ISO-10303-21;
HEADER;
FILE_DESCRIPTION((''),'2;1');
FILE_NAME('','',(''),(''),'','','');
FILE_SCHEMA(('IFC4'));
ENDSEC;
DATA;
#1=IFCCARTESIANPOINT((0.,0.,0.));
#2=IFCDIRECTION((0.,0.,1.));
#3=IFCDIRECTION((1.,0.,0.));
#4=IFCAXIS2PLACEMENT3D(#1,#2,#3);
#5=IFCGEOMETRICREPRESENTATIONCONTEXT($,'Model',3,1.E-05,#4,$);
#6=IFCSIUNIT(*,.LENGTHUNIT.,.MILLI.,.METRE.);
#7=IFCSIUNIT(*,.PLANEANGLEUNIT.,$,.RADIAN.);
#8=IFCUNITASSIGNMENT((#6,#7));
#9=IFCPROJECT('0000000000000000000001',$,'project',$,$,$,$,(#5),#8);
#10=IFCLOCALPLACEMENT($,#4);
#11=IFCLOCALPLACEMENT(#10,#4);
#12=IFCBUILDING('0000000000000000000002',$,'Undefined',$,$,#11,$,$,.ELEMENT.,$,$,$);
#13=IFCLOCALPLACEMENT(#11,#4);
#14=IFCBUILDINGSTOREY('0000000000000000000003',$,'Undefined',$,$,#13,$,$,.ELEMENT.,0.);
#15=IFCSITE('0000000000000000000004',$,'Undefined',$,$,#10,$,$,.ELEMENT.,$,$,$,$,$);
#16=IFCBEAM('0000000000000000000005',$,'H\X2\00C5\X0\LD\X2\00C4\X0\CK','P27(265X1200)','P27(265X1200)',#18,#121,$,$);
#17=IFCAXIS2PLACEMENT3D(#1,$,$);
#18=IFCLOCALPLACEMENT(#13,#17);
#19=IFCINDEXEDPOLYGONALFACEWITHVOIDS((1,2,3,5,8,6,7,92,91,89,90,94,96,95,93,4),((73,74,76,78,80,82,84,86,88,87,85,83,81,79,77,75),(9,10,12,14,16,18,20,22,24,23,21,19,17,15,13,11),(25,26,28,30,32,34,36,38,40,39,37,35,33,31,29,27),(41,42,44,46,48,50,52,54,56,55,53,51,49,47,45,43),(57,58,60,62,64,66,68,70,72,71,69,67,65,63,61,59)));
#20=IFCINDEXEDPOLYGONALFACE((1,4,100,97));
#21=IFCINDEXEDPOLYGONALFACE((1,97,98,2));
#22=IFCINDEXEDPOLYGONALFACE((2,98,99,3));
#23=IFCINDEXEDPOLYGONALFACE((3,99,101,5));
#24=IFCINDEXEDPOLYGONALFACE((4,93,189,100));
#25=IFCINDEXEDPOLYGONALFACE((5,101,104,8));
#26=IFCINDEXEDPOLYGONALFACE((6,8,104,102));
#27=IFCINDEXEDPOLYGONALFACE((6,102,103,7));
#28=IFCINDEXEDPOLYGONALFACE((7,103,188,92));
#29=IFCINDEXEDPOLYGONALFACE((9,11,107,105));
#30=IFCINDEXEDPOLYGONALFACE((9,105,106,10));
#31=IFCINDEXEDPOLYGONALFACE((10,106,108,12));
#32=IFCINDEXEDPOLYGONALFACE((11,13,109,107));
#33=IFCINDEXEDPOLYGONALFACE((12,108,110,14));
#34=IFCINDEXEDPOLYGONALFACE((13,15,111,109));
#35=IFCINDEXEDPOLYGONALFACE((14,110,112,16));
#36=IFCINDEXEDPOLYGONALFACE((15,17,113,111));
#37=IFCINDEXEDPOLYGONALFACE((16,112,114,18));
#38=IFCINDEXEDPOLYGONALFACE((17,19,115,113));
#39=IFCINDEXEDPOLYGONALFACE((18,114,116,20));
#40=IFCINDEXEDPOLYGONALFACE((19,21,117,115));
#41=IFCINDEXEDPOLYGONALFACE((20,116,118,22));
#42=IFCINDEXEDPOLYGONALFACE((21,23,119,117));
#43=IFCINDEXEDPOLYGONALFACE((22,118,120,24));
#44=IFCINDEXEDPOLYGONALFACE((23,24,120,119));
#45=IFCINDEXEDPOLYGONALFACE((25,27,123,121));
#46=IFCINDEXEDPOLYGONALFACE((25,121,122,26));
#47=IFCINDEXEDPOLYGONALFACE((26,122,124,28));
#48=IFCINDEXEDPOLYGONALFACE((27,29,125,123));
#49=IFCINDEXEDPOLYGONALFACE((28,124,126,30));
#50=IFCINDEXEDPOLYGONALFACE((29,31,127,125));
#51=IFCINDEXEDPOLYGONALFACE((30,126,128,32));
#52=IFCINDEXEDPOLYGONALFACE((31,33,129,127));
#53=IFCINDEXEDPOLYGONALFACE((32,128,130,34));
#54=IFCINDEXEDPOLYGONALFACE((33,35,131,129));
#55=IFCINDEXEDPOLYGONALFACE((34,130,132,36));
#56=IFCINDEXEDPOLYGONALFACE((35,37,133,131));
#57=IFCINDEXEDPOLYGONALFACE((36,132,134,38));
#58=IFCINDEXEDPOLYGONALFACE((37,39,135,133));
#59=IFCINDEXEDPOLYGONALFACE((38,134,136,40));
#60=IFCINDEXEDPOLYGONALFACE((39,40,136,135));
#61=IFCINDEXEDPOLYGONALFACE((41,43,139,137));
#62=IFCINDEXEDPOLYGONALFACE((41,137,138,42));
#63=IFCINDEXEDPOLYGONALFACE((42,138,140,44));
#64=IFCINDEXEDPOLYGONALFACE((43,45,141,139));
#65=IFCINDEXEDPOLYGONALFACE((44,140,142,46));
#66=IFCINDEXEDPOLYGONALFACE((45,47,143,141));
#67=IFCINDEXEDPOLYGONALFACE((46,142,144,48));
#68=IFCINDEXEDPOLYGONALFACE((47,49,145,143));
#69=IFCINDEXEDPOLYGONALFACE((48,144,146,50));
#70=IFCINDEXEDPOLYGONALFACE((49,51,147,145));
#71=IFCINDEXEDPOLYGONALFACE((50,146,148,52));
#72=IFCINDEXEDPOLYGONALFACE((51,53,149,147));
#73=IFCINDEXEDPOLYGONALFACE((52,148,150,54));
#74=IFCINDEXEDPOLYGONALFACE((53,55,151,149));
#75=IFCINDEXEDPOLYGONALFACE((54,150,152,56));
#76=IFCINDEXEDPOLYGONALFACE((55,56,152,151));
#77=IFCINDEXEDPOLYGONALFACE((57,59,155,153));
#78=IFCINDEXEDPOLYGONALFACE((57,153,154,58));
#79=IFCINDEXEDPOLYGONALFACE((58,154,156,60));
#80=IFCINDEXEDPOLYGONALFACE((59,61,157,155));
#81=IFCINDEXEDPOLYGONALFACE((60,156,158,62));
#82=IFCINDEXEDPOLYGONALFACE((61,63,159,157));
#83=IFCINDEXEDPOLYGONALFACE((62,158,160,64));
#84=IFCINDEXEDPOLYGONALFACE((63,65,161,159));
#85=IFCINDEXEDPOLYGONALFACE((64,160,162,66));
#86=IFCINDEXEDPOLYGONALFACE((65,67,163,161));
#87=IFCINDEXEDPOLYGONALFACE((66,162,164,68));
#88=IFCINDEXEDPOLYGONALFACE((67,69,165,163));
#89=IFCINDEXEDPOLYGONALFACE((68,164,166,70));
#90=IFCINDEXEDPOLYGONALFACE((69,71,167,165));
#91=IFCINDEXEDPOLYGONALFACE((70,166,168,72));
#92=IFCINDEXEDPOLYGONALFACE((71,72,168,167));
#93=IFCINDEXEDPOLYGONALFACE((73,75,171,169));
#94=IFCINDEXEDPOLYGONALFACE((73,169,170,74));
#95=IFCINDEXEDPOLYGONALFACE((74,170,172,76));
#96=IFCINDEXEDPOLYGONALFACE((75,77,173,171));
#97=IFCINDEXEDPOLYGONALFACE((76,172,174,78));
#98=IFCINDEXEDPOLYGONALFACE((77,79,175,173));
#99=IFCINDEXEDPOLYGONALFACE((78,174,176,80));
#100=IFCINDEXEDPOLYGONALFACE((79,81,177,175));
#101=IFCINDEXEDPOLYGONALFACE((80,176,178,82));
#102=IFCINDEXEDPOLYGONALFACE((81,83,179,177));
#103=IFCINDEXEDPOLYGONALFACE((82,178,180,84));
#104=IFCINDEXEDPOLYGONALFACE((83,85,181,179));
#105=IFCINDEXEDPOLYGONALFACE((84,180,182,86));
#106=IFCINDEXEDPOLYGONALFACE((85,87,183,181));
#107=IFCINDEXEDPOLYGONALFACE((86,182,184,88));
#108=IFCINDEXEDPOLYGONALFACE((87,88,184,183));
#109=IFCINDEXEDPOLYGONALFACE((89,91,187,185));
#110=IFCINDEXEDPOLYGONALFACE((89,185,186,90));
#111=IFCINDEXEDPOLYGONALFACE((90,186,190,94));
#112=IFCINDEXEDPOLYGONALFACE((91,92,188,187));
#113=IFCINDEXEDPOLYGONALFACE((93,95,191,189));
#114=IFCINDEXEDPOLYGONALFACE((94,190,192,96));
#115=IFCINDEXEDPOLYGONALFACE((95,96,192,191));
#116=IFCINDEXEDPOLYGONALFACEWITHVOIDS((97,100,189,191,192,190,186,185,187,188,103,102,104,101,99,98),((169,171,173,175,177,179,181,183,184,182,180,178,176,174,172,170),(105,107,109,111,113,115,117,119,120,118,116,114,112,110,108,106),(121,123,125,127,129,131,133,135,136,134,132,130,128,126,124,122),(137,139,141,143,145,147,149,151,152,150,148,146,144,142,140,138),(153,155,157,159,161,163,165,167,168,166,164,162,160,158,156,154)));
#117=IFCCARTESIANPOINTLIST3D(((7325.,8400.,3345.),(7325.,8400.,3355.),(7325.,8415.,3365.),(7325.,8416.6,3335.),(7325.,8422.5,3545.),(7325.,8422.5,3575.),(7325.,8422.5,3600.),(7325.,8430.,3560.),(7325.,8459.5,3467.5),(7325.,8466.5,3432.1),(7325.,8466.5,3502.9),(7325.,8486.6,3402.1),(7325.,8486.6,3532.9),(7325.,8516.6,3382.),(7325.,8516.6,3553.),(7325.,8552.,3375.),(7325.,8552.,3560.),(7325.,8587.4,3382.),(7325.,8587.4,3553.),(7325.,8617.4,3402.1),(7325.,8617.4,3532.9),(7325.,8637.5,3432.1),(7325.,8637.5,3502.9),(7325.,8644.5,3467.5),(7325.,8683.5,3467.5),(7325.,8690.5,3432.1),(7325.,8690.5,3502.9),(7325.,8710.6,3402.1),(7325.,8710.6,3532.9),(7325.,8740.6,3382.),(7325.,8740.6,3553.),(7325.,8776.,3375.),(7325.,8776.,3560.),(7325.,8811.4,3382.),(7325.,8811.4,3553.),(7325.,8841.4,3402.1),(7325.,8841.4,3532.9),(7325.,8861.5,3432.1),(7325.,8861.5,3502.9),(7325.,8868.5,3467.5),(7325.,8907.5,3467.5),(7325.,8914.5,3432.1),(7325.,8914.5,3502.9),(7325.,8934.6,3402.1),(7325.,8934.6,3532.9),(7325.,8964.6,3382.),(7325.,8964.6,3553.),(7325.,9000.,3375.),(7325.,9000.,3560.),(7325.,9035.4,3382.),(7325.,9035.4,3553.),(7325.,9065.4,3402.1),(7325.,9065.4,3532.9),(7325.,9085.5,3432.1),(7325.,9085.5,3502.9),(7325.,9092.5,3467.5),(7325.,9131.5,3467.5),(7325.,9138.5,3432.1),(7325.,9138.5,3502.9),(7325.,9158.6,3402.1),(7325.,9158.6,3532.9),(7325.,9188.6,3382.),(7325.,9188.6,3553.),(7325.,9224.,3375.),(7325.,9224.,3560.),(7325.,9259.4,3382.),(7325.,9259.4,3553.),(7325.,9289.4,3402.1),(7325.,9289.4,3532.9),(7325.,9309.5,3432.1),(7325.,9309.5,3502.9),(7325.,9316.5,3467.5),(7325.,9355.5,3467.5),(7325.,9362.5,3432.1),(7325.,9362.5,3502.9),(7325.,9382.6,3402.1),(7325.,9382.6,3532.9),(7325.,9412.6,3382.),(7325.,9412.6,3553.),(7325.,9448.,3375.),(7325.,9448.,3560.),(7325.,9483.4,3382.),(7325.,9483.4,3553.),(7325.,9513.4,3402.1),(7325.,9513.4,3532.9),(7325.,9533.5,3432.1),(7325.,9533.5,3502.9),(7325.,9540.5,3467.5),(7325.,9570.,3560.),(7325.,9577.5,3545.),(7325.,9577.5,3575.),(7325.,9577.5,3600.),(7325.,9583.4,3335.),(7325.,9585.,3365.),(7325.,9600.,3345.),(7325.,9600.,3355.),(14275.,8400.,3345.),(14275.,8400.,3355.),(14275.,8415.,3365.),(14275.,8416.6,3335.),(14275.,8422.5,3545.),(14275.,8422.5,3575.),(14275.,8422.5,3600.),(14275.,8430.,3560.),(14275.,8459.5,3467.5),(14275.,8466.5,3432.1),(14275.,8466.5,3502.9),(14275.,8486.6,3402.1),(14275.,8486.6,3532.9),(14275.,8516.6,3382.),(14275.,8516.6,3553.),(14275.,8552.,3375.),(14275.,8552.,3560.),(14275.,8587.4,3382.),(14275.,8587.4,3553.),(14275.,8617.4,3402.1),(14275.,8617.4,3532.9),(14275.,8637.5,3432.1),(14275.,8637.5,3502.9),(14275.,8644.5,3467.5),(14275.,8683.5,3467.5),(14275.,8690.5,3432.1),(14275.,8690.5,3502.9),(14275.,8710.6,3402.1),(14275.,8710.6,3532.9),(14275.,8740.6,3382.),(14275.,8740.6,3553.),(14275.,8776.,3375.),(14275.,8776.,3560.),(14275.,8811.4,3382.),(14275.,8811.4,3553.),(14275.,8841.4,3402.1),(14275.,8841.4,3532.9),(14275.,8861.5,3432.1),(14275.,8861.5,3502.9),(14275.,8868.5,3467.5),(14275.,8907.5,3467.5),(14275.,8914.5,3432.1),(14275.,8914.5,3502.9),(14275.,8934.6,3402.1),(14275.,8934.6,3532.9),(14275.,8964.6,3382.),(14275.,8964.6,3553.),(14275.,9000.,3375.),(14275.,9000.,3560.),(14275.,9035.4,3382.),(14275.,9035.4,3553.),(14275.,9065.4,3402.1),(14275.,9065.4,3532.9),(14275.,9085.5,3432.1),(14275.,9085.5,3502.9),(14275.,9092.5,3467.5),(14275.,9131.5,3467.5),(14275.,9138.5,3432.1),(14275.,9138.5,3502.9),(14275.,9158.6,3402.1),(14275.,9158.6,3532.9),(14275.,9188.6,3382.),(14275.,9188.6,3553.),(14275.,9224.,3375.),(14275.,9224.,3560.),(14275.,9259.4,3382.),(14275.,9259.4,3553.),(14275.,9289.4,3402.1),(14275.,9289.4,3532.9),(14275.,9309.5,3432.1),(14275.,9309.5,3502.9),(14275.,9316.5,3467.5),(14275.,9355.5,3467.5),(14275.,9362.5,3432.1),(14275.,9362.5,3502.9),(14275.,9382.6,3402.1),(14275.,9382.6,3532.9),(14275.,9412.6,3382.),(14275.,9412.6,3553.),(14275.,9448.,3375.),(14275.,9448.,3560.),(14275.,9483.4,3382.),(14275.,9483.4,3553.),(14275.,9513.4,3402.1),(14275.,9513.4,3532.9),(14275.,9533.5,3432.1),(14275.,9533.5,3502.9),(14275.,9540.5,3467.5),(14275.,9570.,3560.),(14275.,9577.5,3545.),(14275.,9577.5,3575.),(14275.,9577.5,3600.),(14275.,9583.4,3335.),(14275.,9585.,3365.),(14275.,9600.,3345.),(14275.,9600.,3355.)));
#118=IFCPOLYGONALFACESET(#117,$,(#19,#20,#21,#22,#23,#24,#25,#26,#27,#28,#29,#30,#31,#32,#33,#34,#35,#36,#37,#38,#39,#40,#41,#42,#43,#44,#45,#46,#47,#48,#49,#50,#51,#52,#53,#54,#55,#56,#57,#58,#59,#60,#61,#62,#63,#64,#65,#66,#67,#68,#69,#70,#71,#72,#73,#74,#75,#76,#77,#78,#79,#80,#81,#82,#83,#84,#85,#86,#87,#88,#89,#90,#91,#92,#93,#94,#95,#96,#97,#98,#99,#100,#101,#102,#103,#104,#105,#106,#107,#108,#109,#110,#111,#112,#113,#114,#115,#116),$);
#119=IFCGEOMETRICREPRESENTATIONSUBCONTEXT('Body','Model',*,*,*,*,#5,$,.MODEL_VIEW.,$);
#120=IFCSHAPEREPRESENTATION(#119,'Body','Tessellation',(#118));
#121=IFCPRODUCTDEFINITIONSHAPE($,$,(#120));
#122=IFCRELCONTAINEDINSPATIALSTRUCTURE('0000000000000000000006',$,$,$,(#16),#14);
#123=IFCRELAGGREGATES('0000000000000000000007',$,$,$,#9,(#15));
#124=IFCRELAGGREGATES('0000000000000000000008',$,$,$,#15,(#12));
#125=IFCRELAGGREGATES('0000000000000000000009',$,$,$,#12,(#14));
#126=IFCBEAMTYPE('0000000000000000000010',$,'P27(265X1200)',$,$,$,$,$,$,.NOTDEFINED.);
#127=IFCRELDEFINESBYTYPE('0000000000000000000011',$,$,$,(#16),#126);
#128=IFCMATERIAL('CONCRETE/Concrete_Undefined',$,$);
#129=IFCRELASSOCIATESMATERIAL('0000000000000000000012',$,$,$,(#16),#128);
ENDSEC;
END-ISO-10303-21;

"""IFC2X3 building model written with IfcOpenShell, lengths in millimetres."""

from ifc_helpers import new_model, si_unit, frame, origin_with_axes, place, context, subcontext, project, spatial, polyline, outline, extrude, material, type_object, element, save


model = new_model("IFC2X3")

# Units and contexts
model_context = context("Model", 3, precision=1e-05, world=origin_with_axes())
body_context = subcontext(model_context, "Body", "Model", "MODEL_VIEW")
ifc_project = project(units=[si_unit("LENGTHUNIT", "METRE", prefix="MILLI"), si_unit("PLANEANGLEUNIT", "RADIAN")], contexts=[model_context])

# Site, building, storey
site_placement = place(None, origin_with_axes())
site = spatial("IfcSite", under=ifc_project, at=site_placement, Name="Undefined", CompositionType="ELEMENT")
building_placement = place(site_placement, origin_with_axes())
building = spatial("IfcBuilding", under=site, at=building_placement, Name="Undefined", CompositionType="ELEMENT")
storey_placement = place(building_placement, origin_with_axes())
storey = spatial("IfcBuildingStorey", under=building, at=storey_placement, Name="Undefined", CompositionType="ELEMENT", Elevation=0.0)

# Beam
ifc_material_1 = material(Name="CONCRETE/Concrete_Undefined")
beam_type_1 = type_object("IfcBeamType", Name="P27(265X1200)", PredefinedType="NOTDEFINED")
beam_1_placement = place(storey_placement, frame((7325.0, 9000.0, 3467.5), z_axis=(0.0, 0.0, 1.0), x_axis=(1.0, 0.0, 0.0)))
element("IfcBeam", 1, at=beam_1_placement, inside=storey, type_object=beam_type_1, material=ifc_material_1, Name="HÅLDÄCK", Description="P27(265X1200)", ObjectType="P27(265X1200)", context=body_context, shape_type="SweptSolid", body=[
    extrude(outline(polyline([(-583.4, -132.5), (-600.0, -122.5), (-600.0, -112.5), (-585.0, -102.5), (-577.5, 77.5), (-570.0, 92.5), (-577.5, 107.5), (-577.5, 132.5), (577.5, 132.5), (577.5, 107.5), (570.0, 92.5), (577.5, 77.5), (585.0, -102.5), (600.0, -112.5), (600.0, -122.5), (583.4, -132.5), (-583.4, -132.5)]), holes=[polyline([(-513.4, 65.4), (-533.5, 35.4), (-540.5, 0.0), (-533.5, -35.4), (-513.4, -65.4), (-483.4, -85.5), (-448.0, -92.5), (-412.6, -85.5), (-382.6, -65.4), (-362.5, -35.4), (-355.5, 0.0), (-362.5, 35.4), (-382.6, 65.4), (-412.6, 85.5), (-448.0, 92.5), (-483.4, 85.5), (-513.4, 65.4)]), polyline([(-289.4, 65.4), (-309.5, 35.4), (-316.5, 0.0), (-309.5, -35.4), (-289.4, -65.4), (-259.4, -85.5), (-224.0, -92.5), (-188.6, -85.5), (-158.6, -65.4), (-138.5, -35.4), (-131.5, 0.0), (-138.5, 35.4), (-158.6, 65.4), (-188.6, 85.5), (-224.0, 92.5), (-259.4, 85.5), (-289.4, 65.4)]), polyline([(-65.4, 65.4), (-85.5, 35.4), (-92.5, 0.0), (-85.5, -35.4), (-65.4, -65.4), (-35.4, -85.5), (0.0, -92.5), (35.4, -85.5), (65.4, -65.4), (85.5, -35.4), (92.5, 0.0), (85.5, 35.4), (65.4, 65.4), (35.4, 85.5), (0.0, 92.5), (-35.4, 85.5), (-65.4, 65.4)]), polyline([(158.6, 65.4), (138.5, 35.4), (131.5, 0.0), (138.5, -35.4), (158.6, -65.4), (188.6, -85.5), (224.0, -92.5), (259.4, -85.5), (289.4, -65.4), (309.5, -35.4), (316.5, 0.0), (309.5, 35.4), (289.4, 65.4), (259.4, 85.5), (224.0, 92.5), (188.6, 85.5), (158.6, 65.4)]), polyline([(382.6, 65.4), (362.5, 35.4), (355.5, 0.0), (362.5, -35.4), (382.6, -65.4), (412.6, -85.5), (448.0, -92.5), (483.4, -85.5), (513.4, -65.4), (533.5, -35.4), (540.5, 0.0), (533.5, 35.4), (513.4, 65.4), (483.4, 85.5), (448.0, 92.5), (412.6, 85.5), (382.6, 65.4)])]), frame((6950.0, 0.0, 0.0), z_axis=(-1.0, 0.0, 0.0), x_axis=(0.0, -1.0, 0.0)), (0.0, 0.0, 1.0), 6950.0),
])

save(model, "model.ifc")
